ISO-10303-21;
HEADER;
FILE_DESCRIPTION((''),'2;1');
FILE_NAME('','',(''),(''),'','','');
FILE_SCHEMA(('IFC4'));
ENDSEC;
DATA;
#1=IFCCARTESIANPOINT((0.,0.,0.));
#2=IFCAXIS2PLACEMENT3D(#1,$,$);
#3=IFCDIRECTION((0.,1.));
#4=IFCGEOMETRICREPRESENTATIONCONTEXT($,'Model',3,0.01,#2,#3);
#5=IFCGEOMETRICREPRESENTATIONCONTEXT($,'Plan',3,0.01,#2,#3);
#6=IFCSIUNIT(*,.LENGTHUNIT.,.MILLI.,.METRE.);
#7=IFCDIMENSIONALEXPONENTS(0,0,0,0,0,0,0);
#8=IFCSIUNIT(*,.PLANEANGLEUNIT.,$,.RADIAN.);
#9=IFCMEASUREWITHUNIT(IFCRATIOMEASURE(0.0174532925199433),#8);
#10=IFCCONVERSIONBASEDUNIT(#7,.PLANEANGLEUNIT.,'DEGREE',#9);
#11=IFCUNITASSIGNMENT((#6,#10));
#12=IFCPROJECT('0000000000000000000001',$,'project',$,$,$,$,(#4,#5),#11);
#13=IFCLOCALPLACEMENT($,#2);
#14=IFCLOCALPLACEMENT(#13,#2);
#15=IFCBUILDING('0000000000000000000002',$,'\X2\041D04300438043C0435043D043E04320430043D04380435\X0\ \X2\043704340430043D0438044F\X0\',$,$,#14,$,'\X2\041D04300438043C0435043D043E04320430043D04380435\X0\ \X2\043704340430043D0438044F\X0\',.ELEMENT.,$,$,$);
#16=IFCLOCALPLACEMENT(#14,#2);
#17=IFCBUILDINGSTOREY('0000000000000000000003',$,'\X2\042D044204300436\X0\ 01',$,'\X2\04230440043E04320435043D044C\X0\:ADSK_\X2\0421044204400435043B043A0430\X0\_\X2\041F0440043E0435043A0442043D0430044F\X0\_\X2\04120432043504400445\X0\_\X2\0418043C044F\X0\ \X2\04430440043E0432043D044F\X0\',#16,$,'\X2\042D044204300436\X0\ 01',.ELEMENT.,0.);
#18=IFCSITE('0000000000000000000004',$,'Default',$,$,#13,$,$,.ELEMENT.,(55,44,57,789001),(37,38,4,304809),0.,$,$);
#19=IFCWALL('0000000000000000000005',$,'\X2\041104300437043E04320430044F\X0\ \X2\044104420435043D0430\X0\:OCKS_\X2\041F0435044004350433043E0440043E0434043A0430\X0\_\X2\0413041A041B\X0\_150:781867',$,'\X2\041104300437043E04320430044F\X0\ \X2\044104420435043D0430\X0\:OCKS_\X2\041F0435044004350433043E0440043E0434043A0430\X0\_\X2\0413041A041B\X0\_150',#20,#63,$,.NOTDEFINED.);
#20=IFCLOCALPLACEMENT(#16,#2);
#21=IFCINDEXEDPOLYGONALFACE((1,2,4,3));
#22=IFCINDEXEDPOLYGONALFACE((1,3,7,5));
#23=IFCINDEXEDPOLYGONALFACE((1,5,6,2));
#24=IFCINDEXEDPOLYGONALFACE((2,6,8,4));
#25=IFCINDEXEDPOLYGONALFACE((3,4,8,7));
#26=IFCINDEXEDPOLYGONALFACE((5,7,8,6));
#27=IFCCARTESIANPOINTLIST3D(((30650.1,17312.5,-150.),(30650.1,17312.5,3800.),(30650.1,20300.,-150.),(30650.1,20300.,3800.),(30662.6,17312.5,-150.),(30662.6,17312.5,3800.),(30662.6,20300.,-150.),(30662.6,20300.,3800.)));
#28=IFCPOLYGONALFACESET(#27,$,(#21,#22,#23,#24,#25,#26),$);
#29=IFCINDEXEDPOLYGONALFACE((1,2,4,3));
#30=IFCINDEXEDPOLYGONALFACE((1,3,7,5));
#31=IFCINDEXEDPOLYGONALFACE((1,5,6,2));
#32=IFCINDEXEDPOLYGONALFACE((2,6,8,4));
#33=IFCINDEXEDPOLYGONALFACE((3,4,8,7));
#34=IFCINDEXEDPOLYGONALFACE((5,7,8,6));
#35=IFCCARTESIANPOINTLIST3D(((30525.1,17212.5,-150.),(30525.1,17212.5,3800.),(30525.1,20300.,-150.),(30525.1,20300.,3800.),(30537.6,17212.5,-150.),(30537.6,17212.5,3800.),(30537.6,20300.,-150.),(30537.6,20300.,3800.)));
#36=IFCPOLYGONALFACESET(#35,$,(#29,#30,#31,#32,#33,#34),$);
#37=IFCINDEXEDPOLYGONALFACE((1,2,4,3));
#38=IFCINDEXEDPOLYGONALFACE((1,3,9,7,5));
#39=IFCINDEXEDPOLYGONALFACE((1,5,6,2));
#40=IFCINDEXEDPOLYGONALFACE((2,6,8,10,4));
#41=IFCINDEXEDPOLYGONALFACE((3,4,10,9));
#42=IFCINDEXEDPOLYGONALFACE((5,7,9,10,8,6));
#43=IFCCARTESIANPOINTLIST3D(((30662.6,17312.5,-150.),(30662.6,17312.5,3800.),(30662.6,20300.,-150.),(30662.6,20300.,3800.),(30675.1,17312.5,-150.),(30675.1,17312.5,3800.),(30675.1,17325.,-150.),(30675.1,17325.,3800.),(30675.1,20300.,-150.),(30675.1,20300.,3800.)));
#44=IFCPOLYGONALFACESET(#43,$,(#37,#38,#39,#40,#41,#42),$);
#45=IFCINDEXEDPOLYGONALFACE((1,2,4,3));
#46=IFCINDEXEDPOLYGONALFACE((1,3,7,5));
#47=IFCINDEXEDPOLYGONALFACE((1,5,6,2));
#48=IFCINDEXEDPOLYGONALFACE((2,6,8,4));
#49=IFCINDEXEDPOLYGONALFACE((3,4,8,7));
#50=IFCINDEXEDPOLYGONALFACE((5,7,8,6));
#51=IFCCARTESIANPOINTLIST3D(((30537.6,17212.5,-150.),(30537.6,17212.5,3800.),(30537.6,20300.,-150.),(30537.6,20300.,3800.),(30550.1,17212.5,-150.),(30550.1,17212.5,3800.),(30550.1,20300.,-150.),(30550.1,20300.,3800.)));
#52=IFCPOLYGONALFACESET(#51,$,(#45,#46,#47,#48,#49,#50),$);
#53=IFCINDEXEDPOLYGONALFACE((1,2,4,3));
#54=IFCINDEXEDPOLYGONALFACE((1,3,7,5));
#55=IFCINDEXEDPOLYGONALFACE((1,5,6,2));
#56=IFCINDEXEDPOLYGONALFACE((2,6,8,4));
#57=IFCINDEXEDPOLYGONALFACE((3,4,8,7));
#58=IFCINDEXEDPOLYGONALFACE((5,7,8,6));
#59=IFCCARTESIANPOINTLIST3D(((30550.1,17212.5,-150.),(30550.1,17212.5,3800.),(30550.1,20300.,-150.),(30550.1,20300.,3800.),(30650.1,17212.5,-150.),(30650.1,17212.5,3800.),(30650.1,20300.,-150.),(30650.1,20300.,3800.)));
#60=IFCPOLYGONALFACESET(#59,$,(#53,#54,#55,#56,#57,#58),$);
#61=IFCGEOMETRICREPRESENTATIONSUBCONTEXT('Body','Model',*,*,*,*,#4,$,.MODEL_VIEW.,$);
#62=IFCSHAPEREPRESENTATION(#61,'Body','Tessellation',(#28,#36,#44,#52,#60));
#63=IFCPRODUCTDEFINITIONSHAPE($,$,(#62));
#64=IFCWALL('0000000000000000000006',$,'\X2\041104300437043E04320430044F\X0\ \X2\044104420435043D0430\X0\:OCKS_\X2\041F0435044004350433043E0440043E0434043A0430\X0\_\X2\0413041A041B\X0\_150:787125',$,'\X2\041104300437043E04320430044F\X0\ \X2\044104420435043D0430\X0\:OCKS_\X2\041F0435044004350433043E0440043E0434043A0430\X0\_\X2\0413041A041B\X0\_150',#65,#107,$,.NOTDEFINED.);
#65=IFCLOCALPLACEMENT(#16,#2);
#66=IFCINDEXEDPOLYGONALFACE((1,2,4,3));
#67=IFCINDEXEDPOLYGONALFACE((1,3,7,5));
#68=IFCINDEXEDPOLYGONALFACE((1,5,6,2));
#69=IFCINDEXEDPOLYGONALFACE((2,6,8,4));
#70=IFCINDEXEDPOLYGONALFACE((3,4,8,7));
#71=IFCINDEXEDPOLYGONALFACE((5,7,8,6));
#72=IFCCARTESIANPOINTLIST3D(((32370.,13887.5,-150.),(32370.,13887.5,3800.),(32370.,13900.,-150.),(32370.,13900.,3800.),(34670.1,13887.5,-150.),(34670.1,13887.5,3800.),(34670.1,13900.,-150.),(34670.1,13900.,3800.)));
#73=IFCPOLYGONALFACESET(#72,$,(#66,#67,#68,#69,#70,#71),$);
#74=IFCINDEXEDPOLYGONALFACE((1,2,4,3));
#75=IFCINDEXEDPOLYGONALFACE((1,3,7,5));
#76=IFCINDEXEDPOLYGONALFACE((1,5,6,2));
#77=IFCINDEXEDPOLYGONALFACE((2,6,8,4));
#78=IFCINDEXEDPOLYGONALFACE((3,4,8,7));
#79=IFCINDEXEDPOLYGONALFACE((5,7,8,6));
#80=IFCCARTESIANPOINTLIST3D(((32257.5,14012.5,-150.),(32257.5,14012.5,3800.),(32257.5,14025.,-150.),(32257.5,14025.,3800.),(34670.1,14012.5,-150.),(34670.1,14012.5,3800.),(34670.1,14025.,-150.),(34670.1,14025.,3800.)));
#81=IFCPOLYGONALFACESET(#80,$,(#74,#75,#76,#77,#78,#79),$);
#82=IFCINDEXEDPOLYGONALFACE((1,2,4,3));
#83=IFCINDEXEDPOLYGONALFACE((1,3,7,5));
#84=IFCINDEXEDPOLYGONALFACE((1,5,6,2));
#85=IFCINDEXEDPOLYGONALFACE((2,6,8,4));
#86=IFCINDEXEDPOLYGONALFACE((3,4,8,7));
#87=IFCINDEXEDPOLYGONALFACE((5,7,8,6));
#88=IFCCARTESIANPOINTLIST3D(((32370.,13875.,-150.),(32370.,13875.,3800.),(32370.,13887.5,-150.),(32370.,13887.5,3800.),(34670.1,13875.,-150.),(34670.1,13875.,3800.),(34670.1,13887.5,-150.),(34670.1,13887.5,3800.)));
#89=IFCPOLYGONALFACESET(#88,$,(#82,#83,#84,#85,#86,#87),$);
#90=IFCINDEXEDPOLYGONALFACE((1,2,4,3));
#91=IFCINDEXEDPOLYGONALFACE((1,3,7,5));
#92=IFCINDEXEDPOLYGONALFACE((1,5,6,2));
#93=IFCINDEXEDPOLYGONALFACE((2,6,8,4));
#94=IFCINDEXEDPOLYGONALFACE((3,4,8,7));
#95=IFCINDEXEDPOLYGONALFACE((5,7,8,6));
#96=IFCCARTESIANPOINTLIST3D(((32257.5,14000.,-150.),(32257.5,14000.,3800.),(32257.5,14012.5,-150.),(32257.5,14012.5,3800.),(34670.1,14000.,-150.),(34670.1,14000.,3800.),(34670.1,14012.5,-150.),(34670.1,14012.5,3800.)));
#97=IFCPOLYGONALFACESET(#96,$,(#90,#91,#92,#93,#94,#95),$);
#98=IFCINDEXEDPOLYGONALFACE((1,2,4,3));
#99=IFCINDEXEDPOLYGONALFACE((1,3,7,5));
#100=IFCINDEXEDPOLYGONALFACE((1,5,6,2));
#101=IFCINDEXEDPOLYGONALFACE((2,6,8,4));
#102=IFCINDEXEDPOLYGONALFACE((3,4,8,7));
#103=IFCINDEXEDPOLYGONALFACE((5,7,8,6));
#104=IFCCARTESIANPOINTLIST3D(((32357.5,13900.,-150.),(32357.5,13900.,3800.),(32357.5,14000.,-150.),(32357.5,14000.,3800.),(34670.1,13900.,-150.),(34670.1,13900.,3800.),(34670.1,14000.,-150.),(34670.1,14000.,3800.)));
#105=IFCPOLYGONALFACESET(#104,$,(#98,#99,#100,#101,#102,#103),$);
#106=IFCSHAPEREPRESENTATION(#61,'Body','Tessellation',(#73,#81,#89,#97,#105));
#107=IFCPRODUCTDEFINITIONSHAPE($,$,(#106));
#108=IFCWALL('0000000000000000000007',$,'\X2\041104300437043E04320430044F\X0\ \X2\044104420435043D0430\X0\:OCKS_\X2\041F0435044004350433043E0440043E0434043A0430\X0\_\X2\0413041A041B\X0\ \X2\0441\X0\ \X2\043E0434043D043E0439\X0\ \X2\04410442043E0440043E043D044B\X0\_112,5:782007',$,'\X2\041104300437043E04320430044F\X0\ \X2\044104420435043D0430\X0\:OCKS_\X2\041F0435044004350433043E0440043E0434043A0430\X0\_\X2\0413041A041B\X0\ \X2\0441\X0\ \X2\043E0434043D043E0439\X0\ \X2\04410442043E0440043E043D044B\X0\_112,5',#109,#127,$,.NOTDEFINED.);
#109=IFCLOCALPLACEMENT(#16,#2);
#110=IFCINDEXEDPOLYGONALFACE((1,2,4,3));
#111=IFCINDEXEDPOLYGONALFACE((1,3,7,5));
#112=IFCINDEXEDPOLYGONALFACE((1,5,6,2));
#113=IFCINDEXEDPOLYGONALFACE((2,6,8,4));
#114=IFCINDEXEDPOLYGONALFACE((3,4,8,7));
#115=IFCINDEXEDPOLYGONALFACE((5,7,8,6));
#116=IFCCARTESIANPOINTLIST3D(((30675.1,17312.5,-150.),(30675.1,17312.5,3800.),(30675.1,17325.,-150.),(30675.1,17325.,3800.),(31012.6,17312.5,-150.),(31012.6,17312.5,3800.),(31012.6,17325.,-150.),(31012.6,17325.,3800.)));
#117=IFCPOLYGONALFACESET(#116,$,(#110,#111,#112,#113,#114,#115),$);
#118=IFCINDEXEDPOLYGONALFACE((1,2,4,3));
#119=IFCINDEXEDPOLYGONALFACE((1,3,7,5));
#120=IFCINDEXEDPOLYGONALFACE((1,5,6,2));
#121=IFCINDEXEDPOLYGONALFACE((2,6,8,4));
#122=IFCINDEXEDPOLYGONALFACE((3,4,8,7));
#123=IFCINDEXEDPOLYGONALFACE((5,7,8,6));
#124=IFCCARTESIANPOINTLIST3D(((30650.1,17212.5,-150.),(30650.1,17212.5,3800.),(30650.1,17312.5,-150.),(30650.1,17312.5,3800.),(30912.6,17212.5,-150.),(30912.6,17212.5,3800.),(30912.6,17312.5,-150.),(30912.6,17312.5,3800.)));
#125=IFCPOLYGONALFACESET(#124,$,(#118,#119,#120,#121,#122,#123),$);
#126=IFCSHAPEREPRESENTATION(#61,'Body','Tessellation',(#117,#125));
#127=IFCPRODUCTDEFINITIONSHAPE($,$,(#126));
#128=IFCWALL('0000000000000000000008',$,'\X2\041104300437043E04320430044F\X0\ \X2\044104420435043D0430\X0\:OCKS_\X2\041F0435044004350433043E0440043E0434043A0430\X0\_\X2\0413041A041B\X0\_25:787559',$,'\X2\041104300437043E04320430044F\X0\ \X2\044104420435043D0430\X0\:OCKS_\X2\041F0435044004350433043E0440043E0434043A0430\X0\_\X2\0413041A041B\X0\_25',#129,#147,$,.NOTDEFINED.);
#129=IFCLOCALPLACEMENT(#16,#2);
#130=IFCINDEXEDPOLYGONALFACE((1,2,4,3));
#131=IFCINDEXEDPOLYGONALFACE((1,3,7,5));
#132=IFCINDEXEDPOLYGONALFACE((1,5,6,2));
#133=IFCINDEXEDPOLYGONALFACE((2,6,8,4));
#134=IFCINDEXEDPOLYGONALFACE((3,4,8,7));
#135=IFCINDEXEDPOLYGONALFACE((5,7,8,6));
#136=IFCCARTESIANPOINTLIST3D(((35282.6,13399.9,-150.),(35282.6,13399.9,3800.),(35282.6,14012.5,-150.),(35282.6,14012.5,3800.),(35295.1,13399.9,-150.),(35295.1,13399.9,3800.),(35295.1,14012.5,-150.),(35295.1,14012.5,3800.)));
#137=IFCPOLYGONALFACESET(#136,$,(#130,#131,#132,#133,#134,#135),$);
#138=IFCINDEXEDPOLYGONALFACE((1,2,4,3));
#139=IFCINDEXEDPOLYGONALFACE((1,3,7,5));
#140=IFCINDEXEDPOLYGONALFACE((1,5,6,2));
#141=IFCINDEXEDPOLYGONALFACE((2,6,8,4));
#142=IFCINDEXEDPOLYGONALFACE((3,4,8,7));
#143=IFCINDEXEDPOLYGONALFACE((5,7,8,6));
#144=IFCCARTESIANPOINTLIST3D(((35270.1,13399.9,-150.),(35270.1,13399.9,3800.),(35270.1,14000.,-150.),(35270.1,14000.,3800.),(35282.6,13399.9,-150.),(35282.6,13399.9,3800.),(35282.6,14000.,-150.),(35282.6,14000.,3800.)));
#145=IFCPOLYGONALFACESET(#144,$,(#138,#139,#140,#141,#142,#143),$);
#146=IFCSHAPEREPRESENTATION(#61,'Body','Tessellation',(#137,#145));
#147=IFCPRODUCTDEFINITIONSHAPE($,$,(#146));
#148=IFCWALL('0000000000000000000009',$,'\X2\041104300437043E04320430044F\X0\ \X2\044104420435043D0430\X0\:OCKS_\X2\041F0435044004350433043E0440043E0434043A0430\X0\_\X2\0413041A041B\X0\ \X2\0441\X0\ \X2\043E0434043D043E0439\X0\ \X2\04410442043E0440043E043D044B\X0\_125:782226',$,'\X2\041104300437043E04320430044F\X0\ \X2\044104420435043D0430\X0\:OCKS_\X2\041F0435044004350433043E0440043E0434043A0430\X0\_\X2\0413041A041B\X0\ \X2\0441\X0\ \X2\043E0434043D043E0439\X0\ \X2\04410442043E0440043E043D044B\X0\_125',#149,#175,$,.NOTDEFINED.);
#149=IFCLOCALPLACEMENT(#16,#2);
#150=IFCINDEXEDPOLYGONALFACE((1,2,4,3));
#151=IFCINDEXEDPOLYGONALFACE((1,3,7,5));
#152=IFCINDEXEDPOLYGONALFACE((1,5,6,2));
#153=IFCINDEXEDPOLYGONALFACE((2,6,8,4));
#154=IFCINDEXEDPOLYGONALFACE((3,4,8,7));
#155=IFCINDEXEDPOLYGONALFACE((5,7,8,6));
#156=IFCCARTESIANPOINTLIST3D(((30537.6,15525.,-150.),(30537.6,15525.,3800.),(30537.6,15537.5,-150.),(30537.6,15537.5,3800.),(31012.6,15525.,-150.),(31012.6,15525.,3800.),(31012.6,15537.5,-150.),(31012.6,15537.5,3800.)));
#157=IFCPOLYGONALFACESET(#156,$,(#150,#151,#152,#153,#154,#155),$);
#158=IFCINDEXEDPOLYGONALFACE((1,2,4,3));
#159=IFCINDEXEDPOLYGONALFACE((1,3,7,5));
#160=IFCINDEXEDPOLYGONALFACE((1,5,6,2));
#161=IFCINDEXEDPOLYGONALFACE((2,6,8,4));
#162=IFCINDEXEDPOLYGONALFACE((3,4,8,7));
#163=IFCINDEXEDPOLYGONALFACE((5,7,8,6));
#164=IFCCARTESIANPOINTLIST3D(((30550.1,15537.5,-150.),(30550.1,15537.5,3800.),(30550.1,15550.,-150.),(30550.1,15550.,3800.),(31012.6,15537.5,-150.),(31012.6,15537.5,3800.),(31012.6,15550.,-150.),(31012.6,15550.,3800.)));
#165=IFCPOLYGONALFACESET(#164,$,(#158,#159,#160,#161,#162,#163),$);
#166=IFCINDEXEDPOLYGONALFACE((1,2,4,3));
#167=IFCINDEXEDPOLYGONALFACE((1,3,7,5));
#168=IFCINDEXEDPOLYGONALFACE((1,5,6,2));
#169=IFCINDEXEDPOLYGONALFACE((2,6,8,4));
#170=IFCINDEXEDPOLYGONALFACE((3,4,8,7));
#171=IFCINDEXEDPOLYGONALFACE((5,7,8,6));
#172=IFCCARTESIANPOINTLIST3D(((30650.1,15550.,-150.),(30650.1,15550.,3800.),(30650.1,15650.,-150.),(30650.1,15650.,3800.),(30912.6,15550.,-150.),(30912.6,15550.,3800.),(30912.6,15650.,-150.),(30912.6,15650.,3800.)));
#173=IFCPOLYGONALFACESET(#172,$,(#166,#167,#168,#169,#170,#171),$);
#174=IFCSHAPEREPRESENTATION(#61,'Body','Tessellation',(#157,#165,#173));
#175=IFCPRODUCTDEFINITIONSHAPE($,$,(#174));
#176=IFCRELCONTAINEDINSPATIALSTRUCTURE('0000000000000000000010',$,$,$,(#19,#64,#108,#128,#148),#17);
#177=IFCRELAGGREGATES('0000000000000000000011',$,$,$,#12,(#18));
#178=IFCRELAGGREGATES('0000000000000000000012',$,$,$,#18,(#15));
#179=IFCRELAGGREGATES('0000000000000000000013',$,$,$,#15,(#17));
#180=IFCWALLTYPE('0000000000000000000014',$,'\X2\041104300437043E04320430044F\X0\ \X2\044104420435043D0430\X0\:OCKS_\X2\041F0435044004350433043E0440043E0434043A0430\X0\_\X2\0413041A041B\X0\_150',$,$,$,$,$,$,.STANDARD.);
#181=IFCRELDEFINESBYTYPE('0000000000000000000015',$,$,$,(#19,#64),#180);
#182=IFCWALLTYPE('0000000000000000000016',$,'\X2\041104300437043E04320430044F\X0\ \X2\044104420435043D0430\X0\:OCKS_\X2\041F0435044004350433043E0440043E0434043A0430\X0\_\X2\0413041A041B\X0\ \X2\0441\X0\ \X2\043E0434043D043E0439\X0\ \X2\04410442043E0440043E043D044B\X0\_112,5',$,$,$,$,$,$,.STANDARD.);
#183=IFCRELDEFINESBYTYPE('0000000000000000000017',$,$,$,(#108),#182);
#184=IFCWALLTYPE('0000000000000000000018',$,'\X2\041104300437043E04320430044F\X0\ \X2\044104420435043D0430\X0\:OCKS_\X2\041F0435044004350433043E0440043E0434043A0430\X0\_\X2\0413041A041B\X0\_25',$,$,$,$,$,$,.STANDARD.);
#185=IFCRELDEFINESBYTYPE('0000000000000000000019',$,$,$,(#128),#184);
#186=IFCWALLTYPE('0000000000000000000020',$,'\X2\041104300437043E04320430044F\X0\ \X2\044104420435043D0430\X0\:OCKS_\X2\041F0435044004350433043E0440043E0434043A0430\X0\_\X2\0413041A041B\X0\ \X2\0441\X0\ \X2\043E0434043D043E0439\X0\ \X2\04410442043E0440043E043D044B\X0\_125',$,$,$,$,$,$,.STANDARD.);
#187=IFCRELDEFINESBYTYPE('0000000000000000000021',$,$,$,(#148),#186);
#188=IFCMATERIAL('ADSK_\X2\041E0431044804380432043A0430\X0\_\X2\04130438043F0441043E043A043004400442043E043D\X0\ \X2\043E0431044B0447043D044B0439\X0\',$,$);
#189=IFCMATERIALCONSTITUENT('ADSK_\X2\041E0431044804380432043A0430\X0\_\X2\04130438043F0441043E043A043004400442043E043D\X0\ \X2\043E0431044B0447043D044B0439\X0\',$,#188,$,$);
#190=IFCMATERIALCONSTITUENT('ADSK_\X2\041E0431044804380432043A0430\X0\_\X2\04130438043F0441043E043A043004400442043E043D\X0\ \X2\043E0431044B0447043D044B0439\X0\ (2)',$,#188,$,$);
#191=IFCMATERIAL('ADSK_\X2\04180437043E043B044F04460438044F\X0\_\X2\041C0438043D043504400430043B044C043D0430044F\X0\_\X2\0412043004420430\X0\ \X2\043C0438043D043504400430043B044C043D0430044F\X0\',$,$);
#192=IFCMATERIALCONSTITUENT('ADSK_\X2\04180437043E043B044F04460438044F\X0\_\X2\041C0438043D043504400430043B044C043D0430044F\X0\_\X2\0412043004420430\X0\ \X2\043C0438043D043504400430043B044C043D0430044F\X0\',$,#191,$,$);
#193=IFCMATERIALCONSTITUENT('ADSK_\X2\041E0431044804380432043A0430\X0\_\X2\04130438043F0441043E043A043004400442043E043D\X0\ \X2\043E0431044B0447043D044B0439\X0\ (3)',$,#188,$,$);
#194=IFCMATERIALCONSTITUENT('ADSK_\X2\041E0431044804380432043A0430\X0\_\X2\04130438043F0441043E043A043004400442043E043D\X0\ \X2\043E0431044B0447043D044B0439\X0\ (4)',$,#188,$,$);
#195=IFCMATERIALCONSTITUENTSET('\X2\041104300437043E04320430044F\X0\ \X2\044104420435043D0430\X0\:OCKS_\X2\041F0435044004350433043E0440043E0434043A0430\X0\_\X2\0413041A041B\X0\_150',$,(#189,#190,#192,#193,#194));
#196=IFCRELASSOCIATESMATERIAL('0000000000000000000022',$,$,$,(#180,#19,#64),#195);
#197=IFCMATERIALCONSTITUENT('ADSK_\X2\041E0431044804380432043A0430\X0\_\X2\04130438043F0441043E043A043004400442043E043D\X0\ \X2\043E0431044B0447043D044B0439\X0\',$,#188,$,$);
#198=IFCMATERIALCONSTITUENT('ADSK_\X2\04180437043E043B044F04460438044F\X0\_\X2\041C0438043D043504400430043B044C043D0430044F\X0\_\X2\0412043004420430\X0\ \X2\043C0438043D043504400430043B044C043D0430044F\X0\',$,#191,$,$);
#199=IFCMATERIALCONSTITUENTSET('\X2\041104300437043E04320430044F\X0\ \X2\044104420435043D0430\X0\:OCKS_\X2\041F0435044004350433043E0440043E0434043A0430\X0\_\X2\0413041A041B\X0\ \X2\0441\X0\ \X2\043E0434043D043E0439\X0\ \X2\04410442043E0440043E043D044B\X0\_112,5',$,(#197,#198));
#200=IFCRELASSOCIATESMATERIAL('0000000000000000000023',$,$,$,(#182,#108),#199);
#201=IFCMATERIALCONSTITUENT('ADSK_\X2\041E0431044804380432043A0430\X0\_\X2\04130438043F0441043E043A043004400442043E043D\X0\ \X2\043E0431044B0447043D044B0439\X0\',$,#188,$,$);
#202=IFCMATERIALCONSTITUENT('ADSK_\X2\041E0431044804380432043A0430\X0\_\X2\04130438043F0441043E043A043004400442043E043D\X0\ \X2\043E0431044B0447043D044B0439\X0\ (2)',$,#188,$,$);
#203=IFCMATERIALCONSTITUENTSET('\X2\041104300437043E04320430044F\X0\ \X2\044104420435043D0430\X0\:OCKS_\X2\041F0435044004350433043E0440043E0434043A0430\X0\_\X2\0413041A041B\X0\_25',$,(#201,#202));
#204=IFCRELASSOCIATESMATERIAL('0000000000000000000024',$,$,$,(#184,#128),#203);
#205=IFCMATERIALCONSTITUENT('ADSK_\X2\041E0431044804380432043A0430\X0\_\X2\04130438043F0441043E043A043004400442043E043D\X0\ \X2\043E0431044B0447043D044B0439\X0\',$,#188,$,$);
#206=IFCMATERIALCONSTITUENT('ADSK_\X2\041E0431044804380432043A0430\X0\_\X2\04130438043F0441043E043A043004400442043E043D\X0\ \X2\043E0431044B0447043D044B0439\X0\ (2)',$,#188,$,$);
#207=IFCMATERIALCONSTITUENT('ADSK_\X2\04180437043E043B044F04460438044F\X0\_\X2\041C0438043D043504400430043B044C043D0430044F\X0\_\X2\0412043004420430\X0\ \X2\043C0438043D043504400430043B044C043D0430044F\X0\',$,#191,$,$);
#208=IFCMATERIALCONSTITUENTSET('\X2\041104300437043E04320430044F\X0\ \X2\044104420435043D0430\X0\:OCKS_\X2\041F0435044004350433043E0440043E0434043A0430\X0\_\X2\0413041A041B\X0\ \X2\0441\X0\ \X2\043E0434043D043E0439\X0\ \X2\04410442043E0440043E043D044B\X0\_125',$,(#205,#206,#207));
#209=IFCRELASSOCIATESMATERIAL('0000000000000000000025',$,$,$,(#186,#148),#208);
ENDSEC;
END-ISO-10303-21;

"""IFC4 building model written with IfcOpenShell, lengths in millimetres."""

from ifc_helpers import new_model, entity, si_unit, converted_unit, direction, frame, origin, place, context, subcontext, project, spatial, indexed_curve, outline, extrude, material, constituent, constituent_set, type_object, element, save


model = new_model("IFC4")

# Units and contexts
model_context = context("Model", 3, precision=0.01, world=origin(), true_north=direction((0.0, 1.0)))
plan_context = context("Plan", 3, precision=0.01, world=origin(), true_north=direction((0.0, 1.0)))
body_context = subcontext(model_context, "Body", "Model", "MODEL_VIEW")
ifc_project = project(units=[si_unit("LENGTHUNIT", "METRE", prefix="MILLI"), converted_unit("PLANEANGLEUNIT", "DEGREE", entity("IfcRatioMeasure", 0.0174532925199433), si_unit("PLANEANGLEUNIT", "RADIAN"), dimensions=[0, 0, 0, 0, 0, 0, 0])], contexts=[model_context, plan_context])

# Site, building, storey
site_placement = place(None, frame((0.0, 0.0, 0.0)))
site = spatial("IfcSite", under=ifc_project, at=site_placement, Name="Default", CompositionType="ELEMENT", RefLatitude=(55, 44, 57, 789001), RefLongitude=(37, 38, 4, 304809), RefElevation=0.0)
building_placement = place(site_placement, origin())
building = spatial("IfcBuilding", under=site, at=building_placement, Name="Наименование здания", LongName="Наименование здания", CompositionType="ELEMENT")
storey_placement = place(building_placement, origin())
storey = spatial("IfcBuildingStorey", under=building, at=storey_placement, Name="Этаж 01", ObjectType="Уровень:ADSK_Стрелка_Проектная_Вверх_Имя уровня", LongName="Этаж 01", CompositionType="ELEMENT", Elevation=0.0)

# Shared definitions
ifc_material_1 = material(Name="ADSK_Обшивка_Гипсокартон обычный")
ifc_constituent_1 = constituent(ifc_material_1, Name="ADSK_Обшивка_Гипсокартон обычный")
ifc_constituent_2 = constituent(ifc_material_1, Name="ADSK_Обшивка_Гипсокартон обычный (2)")
ifc_material_2 = material(Name="ADSK_Изоляция_Минеральная_Вата минеральная")
ifc_constituent_3 = constituent(ifc_material_2, Name="ADSK_Изоляция_Минеральная_Вата минеральная")
ifc_constituent_4 = constituent(ifc_material_1, Name="ADSK_Обшивка_Гипсокартон обычный (3)")
ifc_constituent_5 = constituent(ifc_material_1, Name="ADSK_Обшивка_Гипсокартон обычный (4)")
ifc_constituent_set_1 = constituent_set(constituents=[ifc_constituent_1, ifc_constituent_2, ifc_constituent_3, ifc_constituent_4, ifc_constituent_5], Name="Базовая стена:OCKS_Перегородка_ГКЛ_150")
wall_type_1 = type_object("IfcWallType", Name="Базовая стена:OCKS_Перегородка_ГКЛ_150", PredefinedType="STANDARD", material=ifc_constituent_set_1)

# Wall
wall_1_placement = place(storey_placement, frame((30600.1, 20300.0, -150.0), z_axis=(0.0, 0.0, 1.0), x_axis=(0.0, -1.0, 0.0)))
element("IfcWall", 1, at=wall_1_placement, inside=storey, type_object=wall_type_1, material=ifc_constituent_set_1, Name="Базовая стена:OCKS_Перегородка_ГКЛ_150:781867", ObjectType="Базовая стена:OCKS_Перегородка_ГКЛ_150", PredefinedType="NOTDEFINED", context=body_context, shape_type="SweptSolid", body=[
    extrude(outline(indexed_curve([(-1493.8, -6.2), (1493.8, -6.2), (1493.8, 6.3), (-1493.8, 6.3), (-1493.8, -6.2)], self_intersect=False)), frame((1493.8, 56.2, 0.0)), (0.0, 0.0, 1.0), 3950.0),
    extrude(outline(indexed_curve([(-6.3, -1543.8), (6.2, -1543.8), (6.3, 1543.8), (-6.2, 1543.8), (-6.3, -1543.8)], self_intersect=False)), frame((1543.8, -68.7, 0.0), z_axis=(0.0, 0.0, 1.0), x_axis=(0.0, 1.0, 0.0)), (0.0, 0.0, 1.0), 3950.0),
    extrude(outline(indexed_curve([(-1185.0, -5.0), (1790.0, -5.0), (1790.0, 7.5), (-1197.5, 7.5), (-1197.5, -5.0), (-1185.0, -5.0)], self_intersect=False)), frame((1790.0, 70.0, 0.0), z_axis=(0.0, 0.0, 1.0), x_axis=(-1.0, 0.0, 0.0)), (0.0, 0.0, 1.0), 3950.0),
    extrude(outline(indexed_curve([(-1543.8, -6.2), (1543.8, -6.2), (1543.8, 6.3), (-1543.8, 6.3), (-1543.8, -6.2)], self_intersect=False)), frame((1543.8, -56.3, 0.0)), (0.0, 0.0, 1.0), 3950.0),
    extrude(outline(indexed_curve([(-1543.8, -50.0), (1543.8, -50.0), (1543.8, 50.0), (-1543.8, 50.0), (-1543.8, -50.0)], self_intersect=False)), frame((1543.8, 0.0, 0.0)), (0.0, 0.0, 1.0), 3950.0),
])

# Walls
wall_2_placement = place(storey_placement, frame((32370.0, 13950.0, -150.0)))
element("IfcWall", 2, at=wall_2_placement, inside=storey, type_object=wall_type_1, material=ifc_constituent_set_1, Name="Базовая стена:OCKS_Перегородка_ГКЛ_150:787125", ObjectType="Базовая стена:OCKS_Перегородка_ГКЛ_150", PredefinedType="NOTDEFINED", context=body_context, shape_type="SweptSolid", body=[
    extrude(outline(indexed_curve([(-1150.1, -6.3), (1150.1, -6.3), (1150.1, 6.2), (-1150.1, 6.2), (-1150.1, -6.3)], self_intersect=False)), frame((1150.1, -56.3, 0.0)), (0.0, 0.0, 1.0), 3950.0),
    extrude(outline(indexed_curve([(-6.3, -1206.3), (6.2, -1206.3), (6.3, 1206.3), (-6.2, 1206.3), (-6.3, -1206.3)], self_intersect=False)), frame((1093.8, 68.7, 0.0), z_axis=(0.0, 0.0, 1.0), x_axis=(0.0, -1.0, 0.0)), (0.0, 0.0, 1.0), 3950.0),
    extrude(outline(indexed_curve([(-6.3, -1150.1), (6.2, -1150.1), (6.3, 1150.1), (-6.2, 1150.1), (-6.3, -1150.1)], self_intersect=False)), frame((1150.1, -68.8, 0.0), z_axis=(0.0, 0.0, 1.0), x_axis=(0.0, 1.0, 0.0)), (0.0, 0.0, 1.0), 3950.0),
    extrude(outline(indexed_curve([(-1206.3, -6.3), (1206.3, -6.3), (1206.3, 6.2), (-1206.3, 6.2), (-1206.3, -6.3)], self_intersect=False)), frame((1093.8, 56.3, 0.0)), (0.0, 0.0, 1.0), 3950.0),
    extrude(outline(indexed_curve([(-1156.3, -50.0), (1156.3, -50.0), (1156.3, 50.0), (-1156.3, 50.0), (-1156.3, -50.0)], self_intersect=False)), frame((1143.8, 0.0, 0.0)), (0.0, 0.0, 1.0), 3950.0),
])
ifc_constituent_6 = constituent(ifc_material_1, Name="ADSK_Обшивка_Гипсокартон обычный")
ifc_constituent_7 = constituent(ifc_material_2, Name="ADSK_Изоляция_Минеральная_Вата минеральная")
ifc_constituent_set_2 = constituent_set(constituents=[ifc_constituent_6, ifc_constituent_7], Name="Базовая стена:OCKS_Перегородка_ГКЛ с одной стороны_112,5")
wall_type_2 = type_object("IfcWallType", Name="Базовая стена:OCKS_Перегородка_ГКЛ с одной стороны_112,5", PredefinedType="STANDARD", material=ifc_constituent_set_2)
wall_3_placement = place(storey_placement, frame((30912.6, 17268.7, -150.0), z_axis=(0.0, 0.0, 1.0), x_axis=(-1.0, 0.0, 0.0)))
element("IfcWall", 3, at=wall_3_placement, inside=storey, type_object=wall_type_2, material=ifc_constituent_set_2, Name="Базовая стена:OCKS_Перегородка_ГКЛ с одной стороны_112,5:782007", ObjectType="Базовая стена:OCKS_Перегородка_ГКЛ с одной стороны_112,5", PredefinedType="NOTDEFINED", context=body_context, shape_type="SweptSolid", body=[
    extrude(outline(indexed_curve([(-6.3, -168.8), (6.2, -168.8), (6.3, 168.8), (-6.2, 168.8), (-6.3, -168.8)], self_intersect=False)), frame((68.8, -50.0, 0.0), z_axis=(0.0, 0.0, 1.0), x_axis=(0.0, 1.0, 0.0)), (0.0, 0.0, 1.0), 3950.0),
    extrude(outline(indexed_curve([(-50.0, -131.3), (50.0, -131.3), (50.0, 131.3), (-50.0, 131.3), (-50.0, -131.3)], self_intersect=False)), frame((131.3, 6.3, 0.0), z_axis=(0.0, 0.0, 1.0), x_axis=(0.0, -1.0, 0.0)), (0.0, 0.0, 1.0), 3950.0),
])
ifc_constituent_8 = constituent(ifc_material_1, Name="ADSK_Обшивка_Гипсокартон обычный")
ifc_constituent_9 = constituent(ifc_material_1, Name="ADSK_Обшивка_Гипсокартон обычный (2)")
ifc_constituent_set_3 = constituent_set(constituents=[ifc_constituent_8, ifc_constituent_9], Name="Базовая стена:OCKS_Перегородка_ГКЛ_25")
wall_type_3 = type_object("IfcWallType", Name="Базовая стена:OCKS_Перегородка_ГКЛ_25", PredefinedType="STANDARD", material=ifc_constituent_set_3)
wall_4_placement = place(storey_placement, frame((35282.6, 14000.0, -150.0), z_axis=(0.0, 0.0, 1.0), x_axis=(0.0, -1.0, 0.0)))
element("IfcWall", 4, at=wall_4_placement, inside=storey, type_object=wall_type_3, material=ifc_constituent_set_3, Name="Базовая стена:OCKS_Перегородка_ГКЛ_25:787559", ObjectType="Базовая стена:OCKS_Перегородка_ГКЛ_25", PredefinedType="NOTDEFINED", context=body_context, shape_type="SweptSolid", body=[
    extrude(outline(indexed_curve([(-6.3, -306.3), (6.2, -306.3), (6.2, 306.3), (-6.3, 306.3), (-6.3, -306.3)], self_intersect=False)), frame((293.8, 6.2, 0.0), z_axis=(0.0, 0.0, 1.0), x_axis=(0.0, -1.0, 0.0)), (0.0, 0.0, 1.0), 3950.0),
    extrude(outline(indexed_curve([(-6.2, -300.0), (6.2, -300.0), (6.2, 300.0), (-6.2, 300.0), (-6.2, -300.0)], self_intersect=False)), frame((300.0, -6.2, 0.0), z_axis=(0.0, 0.0, 1.0), x_axis=(0.0, 1.0, 0.0)), (0.0, 0.0, 1.0), 3950.0),
])
ifc_constituent_10 = constituent(ifc_material_1, Name="ADSK_Обшивка_Гипсокартон обычный")
ifc_constituent_11 = constituent(ifc_material_1, Name="ADSK_Обшивка_Гипсокартон обычный (2)")
ifc_constituent_12 = constituent(ifc_material_2, Name="ADSK_Изоляция_Минеральная_Вата минеральная")
ifc_constituent_set_4 = constituent_set(constituents=[ifc_constituent_10, ifc_constituent_11, ifc_constituent_12], Name="Базовая стена:OCKS_Перегородка_ГКЛ с одной стороны_125")
wall_type_4 = type_object("IfcWallType", Name="Базовая стена:OCKS_Перегородка_ГКЛ с одной стороны_125", PredefinedType="STANDARD", material=ifc_constituent_set_4)
wall_5_placement = place(storey_placement, frame((30912.6, 15587.5, -150.0), z_axis=(0.0, 0.0, 1.0), x_axis=(-1.0, 0.0, 0.0)))
element("IfcWall", 5, at=wall_5_placement, inside=storey, type_object=wall_type_4, material=ifc_constituent_set_4, Name="Базовая стена:OCKS_Перегородка_ГКЛ с одной стороны_125:782226", ObjectType="Базовая стена:OCKS_Перегородка_ГКЛ с одной стороны_125", PredefinedType="NOTDEFINED", context=body_context, shape_type="SweptSolid", body=[
    extrude(outline(indexed_curve([(-6.2, -237.5), (6.3, -237.5), (6.3, 237.5), (-6.2, 237.5), (-6.2, -237.5)], self_intersect=False)), frame((137.5, 56.3, 0.0), z_axis=(0.0, 0.0, 1.0), x_axis=(0.0, -1.0, 0.0)), (0.0, 0.0, 1.0), 3950.0),
    extrude(outline(indexed_curve([(-231.3, -6.3), (231.3, -6.3), (231.3, 6.2), (-231.3, 6.2), (-231.3, -6.3)], self_intersect=False)), frame((131.3, 43.8, 0.0)), (0.0, 0.0, 1.0), 3950.0),
    extrude(outline(indexed_curve([(-50.0, -131.3), (50.0, -131.3), (50.0, 131.3), (-50.0, 131.3), (-50.0, -131.3)], self_intersect=False)), frame((131.3, -12.5, 0.0), z_axis=(0.0, 0.0, 1.0), x_axis=(0.0, 1.0, 0.0)), (0.0, 0.0, 1.0), 3950.0),
])

save(model, "model.ifc")
